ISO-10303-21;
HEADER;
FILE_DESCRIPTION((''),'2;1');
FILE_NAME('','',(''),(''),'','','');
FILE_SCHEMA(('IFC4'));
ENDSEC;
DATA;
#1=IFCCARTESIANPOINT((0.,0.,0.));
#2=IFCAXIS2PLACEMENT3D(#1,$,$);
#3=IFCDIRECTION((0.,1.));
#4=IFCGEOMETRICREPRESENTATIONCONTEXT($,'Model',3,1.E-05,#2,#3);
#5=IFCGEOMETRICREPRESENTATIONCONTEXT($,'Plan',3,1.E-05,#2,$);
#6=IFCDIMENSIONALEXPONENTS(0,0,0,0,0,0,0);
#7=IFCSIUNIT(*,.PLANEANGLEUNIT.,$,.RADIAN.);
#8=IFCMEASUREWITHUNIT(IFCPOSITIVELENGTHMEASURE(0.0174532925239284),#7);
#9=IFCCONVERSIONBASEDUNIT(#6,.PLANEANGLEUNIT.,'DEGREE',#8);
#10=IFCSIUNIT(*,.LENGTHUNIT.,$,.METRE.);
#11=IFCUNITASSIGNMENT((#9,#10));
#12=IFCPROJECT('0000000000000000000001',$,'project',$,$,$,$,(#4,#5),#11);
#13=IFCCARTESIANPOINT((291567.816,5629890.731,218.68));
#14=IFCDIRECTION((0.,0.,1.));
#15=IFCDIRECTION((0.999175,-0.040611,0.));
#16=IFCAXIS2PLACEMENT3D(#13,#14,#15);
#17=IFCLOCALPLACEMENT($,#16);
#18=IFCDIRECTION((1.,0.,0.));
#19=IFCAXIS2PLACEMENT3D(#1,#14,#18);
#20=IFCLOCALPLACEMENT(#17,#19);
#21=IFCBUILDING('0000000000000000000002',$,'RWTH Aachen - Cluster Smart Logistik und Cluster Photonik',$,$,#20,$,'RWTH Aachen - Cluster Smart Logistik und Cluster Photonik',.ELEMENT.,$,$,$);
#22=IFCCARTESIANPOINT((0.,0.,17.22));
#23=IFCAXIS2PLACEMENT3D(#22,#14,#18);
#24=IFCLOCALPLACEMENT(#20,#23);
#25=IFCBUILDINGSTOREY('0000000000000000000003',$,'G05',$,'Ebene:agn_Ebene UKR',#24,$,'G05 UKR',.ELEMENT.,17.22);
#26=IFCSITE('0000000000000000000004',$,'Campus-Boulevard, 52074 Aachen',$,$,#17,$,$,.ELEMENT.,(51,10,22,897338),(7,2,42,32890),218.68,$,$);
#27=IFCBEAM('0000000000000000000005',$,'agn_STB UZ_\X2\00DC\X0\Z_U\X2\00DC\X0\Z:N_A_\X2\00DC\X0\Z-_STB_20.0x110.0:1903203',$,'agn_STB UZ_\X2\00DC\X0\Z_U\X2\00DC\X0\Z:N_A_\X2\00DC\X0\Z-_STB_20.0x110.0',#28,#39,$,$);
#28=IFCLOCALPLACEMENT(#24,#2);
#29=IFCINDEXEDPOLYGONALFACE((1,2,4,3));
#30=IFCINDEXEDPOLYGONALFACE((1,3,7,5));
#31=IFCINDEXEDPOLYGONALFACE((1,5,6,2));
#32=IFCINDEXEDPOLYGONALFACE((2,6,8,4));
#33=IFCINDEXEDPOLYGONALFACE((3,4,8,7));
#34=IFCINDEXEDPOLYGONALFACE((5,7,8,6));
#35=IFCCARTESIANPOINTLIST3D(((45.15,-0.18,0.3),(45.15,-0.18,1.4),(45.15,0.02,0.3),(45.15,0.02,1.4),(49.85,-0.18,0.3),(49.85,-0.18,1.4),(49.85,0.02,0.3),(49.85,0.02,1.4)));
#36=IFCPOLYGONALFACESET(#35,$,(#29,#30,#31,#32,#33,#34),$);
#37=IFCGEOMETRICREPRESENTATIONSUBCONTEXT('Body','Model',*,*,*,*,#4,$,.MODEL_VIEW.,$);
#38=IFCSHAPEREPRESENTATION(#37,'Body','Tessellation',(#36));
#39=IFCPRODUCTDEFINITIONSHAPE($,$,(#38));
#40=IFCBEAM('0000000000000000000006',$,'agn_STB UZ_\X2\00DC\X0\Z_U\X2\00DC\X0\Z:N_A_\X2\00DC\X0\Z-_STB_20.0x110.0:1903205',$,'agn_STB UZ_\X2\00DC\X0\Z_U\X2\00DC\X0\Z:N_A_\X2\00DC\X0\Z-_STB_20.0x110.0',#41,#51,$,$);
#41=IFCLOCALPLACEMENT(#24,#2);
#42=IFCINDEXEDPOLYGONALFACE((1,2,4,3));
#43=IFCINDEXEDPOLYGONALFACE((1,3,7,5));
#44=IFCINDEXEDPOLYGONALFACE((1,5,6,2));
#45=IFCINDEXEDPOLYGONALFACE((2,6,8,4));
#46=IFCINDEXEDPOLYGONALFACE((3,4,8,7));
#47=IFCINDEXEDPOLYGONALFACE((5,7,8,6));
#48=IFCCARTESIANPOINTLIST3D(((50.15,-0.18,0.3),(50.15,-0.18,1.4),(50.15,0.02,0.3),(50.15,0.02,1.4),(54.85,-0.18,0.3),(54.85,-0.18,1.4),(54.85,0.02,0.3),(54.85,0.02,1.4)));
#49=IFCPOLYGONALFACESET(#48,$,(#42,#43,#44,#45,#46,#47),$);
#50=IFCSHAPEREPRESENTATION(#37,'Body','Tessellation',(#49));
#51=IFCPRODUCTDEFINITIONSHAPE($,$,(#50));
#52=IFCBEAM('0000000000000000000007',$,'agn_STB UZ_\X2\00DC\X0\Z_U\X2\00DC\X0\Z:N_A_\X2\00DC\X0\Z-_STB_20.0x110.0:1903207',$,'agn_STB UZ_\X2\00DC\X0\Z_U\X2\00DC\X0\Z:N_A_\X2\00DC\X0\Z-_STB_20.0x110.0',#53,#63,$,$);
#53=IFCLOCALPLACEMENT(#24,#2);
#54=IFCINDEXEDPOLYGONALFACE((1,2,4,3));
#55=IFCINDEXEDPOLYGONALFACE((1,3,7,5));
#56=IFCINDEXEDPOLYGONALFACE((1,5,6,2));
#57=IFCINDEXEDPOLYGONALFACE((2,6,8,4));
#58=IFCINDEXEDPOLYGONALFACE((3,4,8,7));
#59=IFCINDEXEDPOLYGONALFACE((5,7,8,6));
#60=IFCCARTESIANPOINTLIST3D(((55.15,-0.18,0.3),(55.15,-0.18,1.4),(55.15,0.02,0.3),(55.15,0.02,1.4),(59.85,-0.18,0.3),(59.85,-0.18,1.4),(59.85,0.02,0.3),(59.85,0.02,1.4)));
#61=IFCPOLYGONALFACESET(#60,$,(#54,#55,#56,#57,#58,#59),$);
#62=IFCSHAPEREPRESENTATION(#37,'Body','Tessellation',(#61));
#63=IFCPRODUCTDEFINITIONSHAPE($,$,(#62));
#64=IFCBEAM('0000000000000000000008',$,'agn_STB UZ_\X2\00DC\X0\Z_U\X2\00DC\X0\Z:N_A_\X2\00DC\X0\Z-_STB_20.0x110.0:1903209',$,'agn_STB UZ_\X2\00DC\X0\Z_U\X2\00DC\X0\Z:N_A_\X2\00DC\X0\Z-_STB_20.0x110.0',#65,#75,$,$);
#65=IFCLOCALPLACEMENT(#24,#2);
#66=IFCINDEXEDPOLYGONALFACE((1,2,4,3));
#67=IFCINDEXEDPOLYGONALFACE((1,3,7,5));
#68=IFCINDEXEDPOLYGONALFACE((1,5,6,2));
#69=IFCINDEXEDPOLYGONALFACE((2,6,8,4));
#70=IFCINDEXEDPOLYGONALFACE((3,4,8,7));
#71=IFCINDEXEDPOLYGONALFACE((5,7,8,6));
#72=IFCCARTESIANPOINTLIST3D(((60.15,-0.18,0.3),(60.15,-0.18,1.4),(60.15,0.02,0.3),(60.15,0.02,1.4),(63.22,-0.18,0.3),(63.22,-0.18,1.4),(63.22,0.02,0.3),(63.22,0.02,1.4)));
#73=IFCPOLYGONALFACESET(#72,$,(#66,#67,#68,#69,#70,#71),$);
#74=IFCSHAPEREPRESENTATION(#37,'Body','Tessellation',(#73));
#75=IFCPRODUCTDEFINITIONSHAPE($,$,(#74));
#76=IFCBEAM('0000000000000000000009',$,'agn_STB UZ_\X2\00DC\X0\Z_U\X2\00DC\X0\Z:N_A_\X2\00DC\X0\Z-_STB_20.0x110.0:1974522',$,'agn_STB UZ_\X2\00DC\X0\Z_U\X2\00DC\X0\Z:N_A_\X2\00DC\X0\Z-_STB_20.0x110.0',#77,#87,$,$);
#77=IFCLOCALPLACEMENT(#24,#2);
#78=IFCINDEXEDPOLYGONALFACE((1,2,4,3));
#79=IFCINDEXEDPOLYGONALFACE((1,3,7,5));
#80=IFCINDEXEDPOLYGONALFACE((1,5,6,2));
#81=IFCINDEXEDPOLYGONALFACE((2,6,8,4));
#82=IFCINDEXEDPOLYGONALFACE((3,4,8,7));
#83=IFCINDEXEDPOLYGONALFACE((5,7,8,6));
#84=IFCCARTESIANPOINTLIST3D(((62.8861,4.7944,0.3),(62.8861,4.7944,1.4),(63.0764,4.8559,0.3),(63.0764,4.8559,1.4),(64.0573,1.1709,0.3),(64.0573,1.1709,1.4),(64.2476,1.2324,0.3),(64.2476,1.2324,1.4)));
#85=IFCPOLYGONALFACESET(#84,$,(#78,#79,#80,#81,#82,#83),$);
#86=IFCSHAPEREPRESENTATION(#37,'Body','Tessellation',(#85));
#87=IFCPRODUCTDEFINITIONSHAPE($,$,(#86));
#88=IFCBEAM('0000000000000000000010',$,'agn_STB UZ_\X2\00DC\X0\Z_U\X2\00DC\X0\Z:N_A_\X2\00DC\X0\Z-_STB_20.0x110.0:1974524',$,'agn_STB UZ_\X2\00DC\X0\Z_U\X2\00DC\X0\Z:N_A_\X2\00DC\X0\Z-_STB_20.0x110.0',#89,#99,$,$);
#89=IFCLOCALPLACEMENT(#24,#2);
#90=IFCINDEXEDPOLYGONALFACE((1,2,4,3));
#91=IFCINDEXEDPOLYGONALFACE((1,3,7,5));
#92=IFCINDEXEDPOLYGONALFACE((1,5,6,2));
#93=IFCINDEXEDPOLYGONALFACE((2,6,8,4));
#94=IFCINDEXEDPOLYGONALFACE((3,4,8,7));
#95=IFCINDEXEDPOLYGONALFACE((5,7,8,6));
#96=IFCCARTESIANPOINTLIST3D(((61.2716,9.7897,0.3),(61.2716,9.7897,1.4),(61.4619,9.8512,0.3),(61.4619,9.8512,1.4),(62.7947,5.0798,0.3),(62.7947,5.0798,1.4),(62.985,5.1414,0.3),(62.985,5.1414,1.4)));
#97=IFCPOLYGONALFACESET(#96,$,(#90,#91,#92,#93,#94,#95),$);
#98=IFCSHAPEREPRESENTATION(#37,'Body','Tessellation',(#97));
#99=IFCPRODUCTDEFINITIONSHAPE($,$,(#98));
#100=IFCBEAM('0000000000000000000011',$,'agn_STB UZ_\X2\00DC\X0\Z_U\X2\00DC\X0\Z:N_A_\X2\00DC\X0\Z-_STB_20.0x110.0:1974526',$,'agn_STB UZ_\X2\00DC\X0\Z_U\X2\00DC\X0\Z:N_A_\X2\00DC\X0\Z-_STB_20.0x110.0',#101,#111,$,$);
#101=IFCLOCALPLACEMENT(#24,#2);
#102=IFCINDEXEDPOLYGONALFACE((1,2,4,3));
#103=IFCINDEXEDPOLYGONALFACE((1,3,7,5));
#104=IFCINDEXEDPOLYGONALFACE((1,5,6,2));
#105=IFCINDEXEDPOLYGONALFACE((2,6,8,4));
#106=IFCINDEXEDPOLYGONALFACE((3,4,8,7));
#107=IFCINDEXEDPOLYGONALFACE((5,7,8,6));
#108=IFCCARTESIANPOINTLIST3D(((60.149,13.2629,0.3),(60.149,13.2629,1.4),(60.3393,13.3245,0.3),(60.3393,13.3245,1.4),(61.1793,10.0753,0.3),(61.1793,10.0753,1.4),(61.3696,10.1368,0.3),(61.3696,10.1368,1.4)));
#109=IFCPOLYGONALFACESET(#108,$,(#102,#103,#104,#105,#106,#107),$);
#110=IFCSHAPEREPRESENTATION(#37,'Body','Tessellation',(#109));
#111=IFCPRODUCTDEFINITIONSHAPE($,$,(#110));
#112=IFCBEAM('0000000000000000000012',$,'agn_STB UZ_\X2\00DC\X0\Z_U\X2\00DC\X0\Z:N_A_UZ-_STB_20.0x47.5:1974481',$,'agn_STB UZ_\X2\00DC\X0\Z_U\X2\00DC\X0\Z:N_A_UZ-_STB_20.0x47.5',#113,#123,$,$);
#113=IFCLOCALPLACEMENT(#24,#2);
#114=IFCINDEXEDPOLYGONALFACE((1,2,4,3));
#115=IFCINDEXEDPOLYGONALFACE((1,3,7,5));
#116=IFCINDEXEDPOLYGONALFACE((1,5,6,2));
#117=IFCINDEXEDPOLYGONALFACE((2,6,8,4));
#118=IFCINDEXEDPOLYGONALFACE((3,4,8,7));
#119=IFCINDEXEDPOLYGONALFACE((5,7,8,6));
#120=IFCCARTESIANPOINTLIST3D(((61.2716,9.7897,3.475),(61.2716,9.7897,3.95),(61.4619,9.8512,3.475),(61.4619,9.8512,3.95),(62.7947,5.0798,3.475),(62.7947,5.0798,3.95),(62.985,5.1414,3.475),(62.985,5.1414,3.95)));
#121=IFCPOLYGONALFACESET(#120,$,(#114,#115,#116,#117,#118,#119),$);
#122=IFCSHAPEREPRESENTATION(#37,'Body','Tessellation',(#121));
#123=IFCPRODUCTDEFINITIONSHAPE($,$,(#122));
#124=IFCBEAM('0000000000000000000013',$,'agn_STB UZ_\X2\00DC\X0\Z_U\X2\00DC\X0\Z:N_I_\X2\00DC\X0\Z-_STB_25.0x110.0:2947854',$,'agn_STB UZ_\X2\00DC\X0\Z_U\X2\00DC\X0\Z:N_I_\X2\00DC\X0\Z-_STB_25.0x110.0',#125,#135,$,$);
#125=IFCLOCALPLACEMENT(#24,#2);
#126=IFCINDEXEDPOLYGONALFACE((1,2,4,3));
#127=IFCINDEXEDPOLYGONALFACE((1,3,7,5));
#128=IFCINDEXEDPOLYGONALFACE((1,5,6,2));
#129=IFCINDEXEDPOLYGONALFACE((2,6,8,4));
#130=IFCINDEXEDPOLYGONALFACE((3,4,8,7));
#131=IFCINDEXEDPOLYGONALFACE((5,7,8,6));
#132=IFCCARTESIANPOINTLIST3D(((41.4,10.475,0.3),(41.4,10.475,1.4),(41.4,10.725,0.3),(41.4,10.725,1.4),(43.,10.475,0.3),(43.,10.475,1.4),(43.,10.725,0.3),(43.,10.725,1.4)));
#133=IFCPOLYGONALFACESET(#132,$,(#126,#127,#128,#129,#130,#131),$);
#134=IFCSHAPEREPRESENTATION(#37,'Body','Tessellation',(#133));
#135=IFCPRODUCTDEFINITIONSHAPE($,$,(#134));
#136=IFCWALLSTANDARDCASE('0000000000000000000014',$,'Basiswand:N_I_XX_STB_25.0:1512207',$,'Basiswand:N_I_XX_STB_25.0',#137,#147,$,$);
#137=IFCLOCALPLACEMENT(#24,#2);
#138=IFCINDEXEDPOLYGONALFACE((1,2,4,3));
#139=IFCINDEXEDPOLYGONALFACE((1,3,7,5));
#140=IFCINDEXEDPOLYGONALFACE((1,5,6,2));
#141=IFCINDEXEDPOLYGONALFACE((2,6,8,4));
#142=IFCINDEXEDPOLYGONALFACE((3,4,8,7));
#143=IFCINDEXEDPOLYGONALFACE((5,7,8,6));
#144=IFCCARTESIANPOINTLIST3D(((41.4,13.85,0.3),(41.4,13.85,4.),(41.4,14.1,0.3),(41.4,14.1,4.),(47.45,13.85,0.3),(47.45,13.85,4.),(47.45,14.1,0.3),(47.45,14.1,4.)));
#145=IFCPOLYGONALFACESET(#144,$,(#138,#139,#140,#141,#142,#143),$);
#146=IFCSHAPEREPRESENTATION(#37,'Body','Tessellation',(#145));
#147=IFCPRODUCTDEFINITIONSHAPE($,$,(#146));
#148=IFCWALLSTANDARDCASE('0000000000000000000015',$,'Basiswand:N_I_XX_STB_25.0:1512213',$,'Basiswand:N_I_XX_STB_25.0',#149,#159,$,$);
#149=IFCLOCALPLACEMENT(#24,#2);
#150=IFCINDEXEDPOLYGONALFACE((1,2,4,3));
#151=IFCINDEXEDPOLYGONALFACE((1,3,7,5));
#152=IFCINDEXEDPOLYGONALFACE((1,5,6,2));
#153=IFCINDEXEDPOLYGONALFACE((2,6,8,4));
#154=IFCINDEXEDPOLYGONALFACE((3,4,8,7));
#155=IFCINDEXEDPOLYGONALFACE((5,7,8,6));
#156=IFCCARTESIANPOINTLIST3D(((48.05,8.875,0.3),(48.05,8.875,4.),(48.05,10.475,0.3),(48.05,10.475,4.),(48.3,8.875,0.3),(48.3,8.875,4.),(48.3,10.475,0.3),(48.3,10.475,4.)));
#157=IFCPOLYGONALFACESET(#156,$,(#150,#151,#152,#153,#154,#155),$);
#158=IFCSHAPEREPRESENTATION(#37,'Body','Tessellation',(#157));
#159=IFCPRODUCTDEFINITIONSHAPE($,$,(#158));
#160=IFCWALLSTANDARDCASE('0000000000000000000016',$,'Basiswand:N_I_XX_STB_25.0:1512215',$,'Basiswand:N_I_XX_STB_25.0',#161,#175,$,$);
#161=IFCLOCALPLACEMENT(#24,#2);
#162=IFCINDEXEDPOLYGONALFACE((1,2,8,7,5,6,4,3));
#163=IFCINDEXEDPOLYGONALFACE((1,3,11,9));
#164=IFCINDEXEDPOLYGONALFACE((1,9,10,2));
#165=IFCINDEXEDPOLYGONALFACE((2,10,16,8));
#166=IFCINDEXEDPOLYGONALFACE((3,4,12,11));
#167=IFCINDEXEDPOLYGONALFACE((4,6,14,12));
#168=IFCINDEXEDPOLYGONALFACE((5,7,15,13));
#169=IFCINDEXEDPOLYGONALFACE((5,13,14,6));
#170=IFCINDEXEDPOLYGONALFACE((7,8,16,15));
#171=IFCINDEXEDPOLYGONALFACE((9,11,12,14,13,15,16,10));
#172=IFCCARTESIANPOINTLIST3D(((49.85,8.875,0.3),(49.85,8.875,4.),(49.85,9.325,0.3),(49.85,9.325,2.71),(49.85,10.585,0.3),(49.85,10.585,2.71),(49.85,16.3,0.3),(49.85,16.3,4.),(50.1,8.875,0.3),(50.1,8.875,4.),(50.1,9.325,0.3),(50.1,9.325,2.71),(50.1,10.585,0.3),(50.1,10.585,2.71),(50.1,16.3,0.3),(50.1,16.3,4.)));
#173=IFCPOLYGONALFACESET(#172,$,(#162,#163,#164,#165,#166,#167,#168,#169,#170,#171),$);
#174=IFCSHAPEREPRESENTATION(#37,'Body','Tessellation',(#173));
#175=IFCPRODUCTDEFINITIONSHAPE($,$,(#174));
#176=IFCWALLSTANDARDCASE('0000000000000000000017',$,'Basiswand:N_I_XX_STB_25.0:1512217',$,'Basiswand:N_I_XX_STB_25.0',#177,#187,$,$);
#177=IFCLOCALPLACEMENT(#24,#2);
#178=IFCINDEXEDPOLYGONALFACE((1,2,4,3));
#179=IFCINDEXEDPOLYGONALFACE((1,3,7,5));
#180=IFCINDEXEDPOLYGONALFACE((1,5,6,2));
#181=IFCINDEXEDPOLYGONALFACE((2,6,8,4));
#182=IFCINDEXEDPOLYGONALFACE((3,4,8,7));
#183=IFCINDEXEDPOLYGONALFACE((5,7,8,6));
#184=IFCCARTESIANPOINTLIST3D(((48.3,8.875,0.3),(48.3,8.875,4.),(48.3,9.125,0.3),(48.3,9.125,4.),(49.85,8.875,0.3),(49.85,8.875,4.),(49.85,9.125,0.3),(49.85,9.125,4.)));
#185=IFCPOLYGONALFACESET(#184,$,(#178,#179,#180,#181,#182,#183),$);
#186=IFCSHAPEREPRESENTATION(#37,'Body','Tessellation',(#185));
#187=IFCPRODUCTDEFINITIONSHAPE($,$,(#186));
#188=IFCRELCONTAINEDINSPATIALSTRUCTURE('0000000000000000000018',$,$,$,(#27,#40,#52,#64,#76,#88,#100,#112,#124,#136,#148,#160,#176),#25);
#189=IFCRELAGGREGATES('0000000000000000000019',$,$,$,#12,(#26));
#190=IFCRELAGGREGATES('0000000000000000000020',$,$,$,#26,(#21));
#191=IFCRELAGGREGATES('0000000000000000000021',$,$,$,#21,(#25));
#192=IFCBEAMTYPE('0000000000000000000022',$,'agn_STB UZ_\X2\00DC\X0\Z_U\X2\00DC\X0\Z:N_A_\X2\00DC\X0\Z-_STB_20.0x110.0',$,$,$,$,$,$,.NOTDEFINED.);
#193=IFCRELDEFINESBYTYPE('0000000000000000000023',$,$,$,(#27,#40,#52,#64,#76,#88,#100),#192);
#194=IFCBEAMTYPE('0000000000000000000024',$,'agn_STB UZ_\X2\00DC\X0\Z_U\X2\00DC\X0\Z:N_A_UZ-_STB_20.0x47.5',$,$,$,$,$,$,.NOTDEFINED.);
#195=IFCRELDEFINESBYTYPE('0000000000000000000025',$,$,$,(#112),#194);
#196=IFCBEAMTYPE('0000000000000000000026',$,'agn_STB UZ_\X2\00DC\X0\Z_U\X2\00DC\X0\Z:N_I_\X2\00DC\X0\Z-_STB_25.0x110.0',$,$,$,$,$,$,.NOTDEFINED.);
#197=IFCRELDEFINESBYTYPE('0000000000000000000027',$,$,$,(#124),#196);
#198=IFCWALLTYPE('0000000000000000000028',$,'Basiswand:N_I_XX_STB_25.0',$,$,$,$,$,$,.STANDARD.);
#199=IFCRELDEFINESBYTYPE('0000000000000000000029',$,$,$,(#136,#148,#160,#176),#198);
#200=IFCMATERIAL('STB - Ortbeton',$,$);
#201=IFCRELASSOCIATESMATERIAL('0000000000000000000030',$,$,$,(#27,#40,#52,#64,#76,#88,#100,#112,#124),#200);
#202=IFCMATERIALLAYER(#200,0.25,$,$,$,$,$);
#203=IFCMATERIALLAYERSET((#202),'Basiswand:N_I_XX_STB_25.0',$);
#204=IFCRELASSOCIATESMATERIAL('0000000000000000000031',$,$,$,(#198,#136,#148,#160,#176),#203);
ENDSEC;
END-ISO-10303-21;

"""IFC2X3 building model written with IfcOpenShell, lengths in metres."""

from ifc_helpers import new_model, entity, si_unit, converted_unit, direction, frame, frame_2d, origin, origin_with_axes, place, context, subcontext, project, spatial, rectangle, extrude, material, layer, layer_set, layer_usage, type_object, element, save


model = new_model("IFC2X3")

# Units and contexts
model_context = context("Model", 3, precision=1e-05, world=origin(), true_north=direction((0.0, 1.0)))
plan_context = context("Plan", 3, precision=1e-05, world=origin())
body_context = subcontext(model_context, "Body", "Model", "MODEL_VIEW")
ifc_project = project(units=[converted_unit("PLANEANGLEUNIT", "DEGREE", entity("IfcPositiveLengthMeasure", 0.0174532925239284), si_unit("PLANEANGLEUNIT", "RADIAN"), dimensions=[0, 0, 0, 0, 0, 0, 0]), si_unit("LENGTHUNIT", "METRE")], contexts=[model_context, plan_context])

# Site, building, storey
site_placement = place(None, frame((291567.816, 5629890.731, 218.68), z_axis=(0.0, 0.0, 1.0), x_axis=(0.999175, -0.040611, 0.0)))
site = spatial("IfcSite", under=ifc_project, at=site_placement, Name="Campus-Boulevard, 52074 Aachen", CompositionType="ELEMENT", RefLatitude=(51, 10, 22, 897338), RefLongitude=(7, 2, 42, 32890), RefElevation=218.68)
building_placement = place(site_placement, origin_with_axes())
building = spatial("IfcBuilding", under=site, at=building_placement, Name="RWTH Aachen - Cluster Smart Logistik und Cluster Photonik", LongName="RWTH Aachen - Cluster Smart Logistik und Cluster Photonik", CompositionType="ELEMENT")
storey_placement = place(building_placement, frame((0.0, 0.0, 17.22), z_axis=(0.0, 0.0, 1.0), x_axis=(1.0, 0.0, 0.0)))
storey = spatial("IfcBuildingStorey", under=building, at=storey_placement, Name="G05", ObjectType="Ebene:agn_Ebene UKR", LongName="G05 UKR", CompositionType="ELEMENT", Elevation=17.22)

# Beams
ifc_material_1 = material(Name="STB - Ortbeton")
beam_type_1 = type_object("IfcBeamType", Name="agn_STB UZ_ÜZ_UÜZ:N_A_ÜZ-_STB_20.0x110.0", PredefinedType="NOTDEFINED")
for number, where, z_axis, x_axis, name in (
    (1, (45.15, -0.08, 0.3), (0.0, 0.0, 1.0), (1.0, 0.0, 0.0), "agn_STB UZ_ÜZ_UÜZ:N_A_ÜZ-_STB_20.0x110.0:1903203"),
    (2, (50.15, -0.08, 0.3), (0.0, 0.0, 1.0), (1.0, 0.0, 0.0), "agn_STB UZ_ÜZ_UÜZ:N_A_ÜZ-_STB_20.0x110.0:1903205"),
    (3, (55.15, -0.08, 0.3), (0.0, 0.0, 1.0), (1.0, 0.0, 0.0), "agn_STB UZ_ÜZ_UÜZ:N_A_ÜZ-_STB_20.0x110.0:1903207"),
):
    element("IfcBeam", number, at=place(storey_placement, frame(where, z_axis=z_axis, x_axis=x_axis)), inside=storey, type_object=beam_type_1, material=ifc_material_1, Name=name, ObjectType="agn_STB UZ_ÜZ_UÜZ:N_A_ÜZ-_STB_20.0x110.0", context=body_context, shape_type="SweptSolid", body=[
        extrude(rectangle(XDim=1.1, YDim=0.2, at=frame_2d((0.0, 0.0), x_axis=(1.0, 0.0))), frame((0.0, 0.0, 0.55), z_axis=(1.0, 0.0, 0.0), x_axis=(0.0, 0.0, -1.0)), (0.0, 0.0, 1.0), 4.7),
    ])
beam_1_placement = place(storey_placement, frame((60.15, -0.08, 0.3), z_axis=(0.0, 0.0, 1.0), x_axis=(1.0, 0.0, 0.0)))
element("IfcBeam", 4, at=beam_1_placement, inside=storey, type_object=beam_type_1, material=ifc_material_1, Name="agn_STB UZ_ÜZ_UÜZ:N_A_ÜZ-_STB_20.0x110.0:1903209", ObjectType="agn_STB UZ_ÜZ_UÜZ:N_A_ÜZ-_STB_20.0x110.0", context=body_context, shape_type="SweptSolid", body=[
    extrude(rectangle(XDim=1.1, YDim=0.2, at=frame_2d((0.0, 0.0), x_axis=(1.0, 0.0))), frame((0.0, 0.0, 0.55), z_axis=(1.0, 0.0, 0.0), x_axis=(0.0, 0.0, -1.0)), (0.0, 0.0, 1.0), 3.07),
])
beam_2_placement = place(storey_placement, frame((62.9812, 4.8253, 0.3), z_axis=(0.0, 0.0, 1.0), x_axis=(0.307544, -0.951534, 0.0)))
element("IfcBeam", 5, at=beam_2_placement, inside=storey, type_object=beam_type_1, material=ifc_material_1, Name="agn_STB UZ_ÜZ_UÜZ:N_A_ÜZ-_STB_20.0x110.0:1974522", ObjectType="agn_STB UZ_ÜZ_UÜZ:N_A_ÜZ-_STB_20.0x110.0", context=body_context, shape_type="SweptSolid", body=[
    extrude(rectangle(XDim=1.1, YDim=0.2, at=frame_2d((0.0, 0.0), x_axis=(1.0, 0.0))), frame((0.0001, 0.0, 0.55), z_axis=(1.0, 0.0, 0.0), x_axis=(0.0, 0.0, -1.0)), (0.0, 0.0, 1.0), 3.8081),
])
beam_3_placement = place(storey_placement, frame((61.3667, 9.8206, 0.3), z_axis=(0.0, 0.0, 1.0), x_axis=(0.307689, -0.951487, 0.0)))
element("IfcBeam", 6, at=beam_3_placement, inside=storey, type_object=beam_type_1, material=ifc_material_1, Name="agn_STB UZ_ÜZ_UÜZ:N_A_ÜZ-_STB_20.0x110.0:1974524", ObjectType="agn_STB UZ_ÜZ_UÜZ:N_A_ÜZ-_STB_20.0x110.0", context=body_context, shape_type="SweptSolid", body=[
    extrude(rectangle(XDim=1.1, YDim=0.2, at=frame_2d((0.0, 0.0), x_axis=(1.0, 0.0))), frame((0.0002, 0.0, 0.55), z_axis=(1.0, 0.0, 0.0), x_axis=(0.0, 0.0, -1.0)), (0.0, 0.0, 1.0), 4.95),
])
beam_4_placement = place(storey_placement, frame((60.2441, 13.294, 0.3), z_axis=(0.0, 0.0, 1.0), x_axis=(0.307544, -0.951534, 0.0)))
element("IfcBeam", 7, at=beam_4_placement, inside=storey, type_object=beam_type_1, material=ifc_material_1, Name="agn_STB UZ_ÜZ_UÜZ:N_A_ÜZ-_STB_20.0x110.0:1974526", ObjectType="agn_STB UZ_ÜZ_UÜZ:N_A_ÜZ-_STB_20.0x110.0", context=body_context, shape_type="SweptSolid", body=[
    extrude(rectangle(XDim=1.1, YDim=0.2, at=frame_2d((0.0, 0.0), x_axis=(1.0, 0.0))), frame((0.0003, 0.0, 0.55), z_axis=(1.0, 0.0, 0.0), x_axis=(0.0, 0.0, -1.0)), (0.0, 0.0, 1.0), 3.35),
])
beam_type_2 = type_object("IfcBeamType", Name="agn_STB UZ_ÜZ_UÜZ:N_A_UZ-_STB_20.0x47.5", PredefinedType="NOTDEFINED")
beam_5_placement = place(storey_placement, frame((61.3667, 9.8206, 0.3), z_axis=(0.0, 0.0, 1.0), x_axis=(0.307689, -0.951487, 0.0)))
element("IfcBeam", 8, at=beam_5_placement, inside=storey, type_object=beam_type_2, material=ifc_material_1, Name="agn_STB UZ_ÜZ_UÜZ:N_A_UZ-_STB_20.0x47.5:1974481", ObjectType="agn_STB UZ_ÜZ_UÜZ:N_A_UZ-_STB_20.0x47.5", context=body_context, shape_type="SweptSolid", body=[
    extrude(rectangle(XDim=0.475, YDim=0.2, at=frame_2d((0.0, 0.0), x_axis=(1.0, 0.0))), frame((0.0002, 0.0, 3.4125), z_axis=(1.0, 0.0, 0.0), x_axis=(0.0, 0.0, -1.0)), (0.0, 0.0, 1.0), 4.95),
])
beam_type_3 = type_object("IfcBeamType", Name="agn_STB UZ_ÜZ_UÜZ:N_I_ÜZ-_STB_25.0x110.0", PredefinedType="NOTDEFINED")
beam_6_placement = place(storey_placement, frame((43.1, 10.6, 0.3), z_axis=(0.0, 0.0, 1.0), x_axis=(-1.0, 0.0, 0.0)))
element("IfcBeam", 9, at=beam_6_placement, inside=storey, type_object=beam_type_3, material=ifc_material_1, Name="agn_STB UZ_ÜZ_UÜZ:N_I_ÜZ-_STB_25.0x110.0:2947854", ObjectType="agn_STB UZ_ÜZ_UÜZ:N_I_ÜZ-_STB_25.0x110.0", context=body_context, shape_type="SweptSolid", body=[
    extrude(rectangle(XDim=1.1, YDim=0.25, at=frame_2d((0.0, 0.0), x_axis=(1.0, 0.0))), frame((0.1, 0.0, 0.55), z_axis=(1.0, 0.0, 0.0), x_axis=(0.0, 0.0, -1.0)), (0.0, 0.0, 1.0), 1.6),
])

# Walls
ifc_layer_1 = layer(ifc_material_1, 0.25)
ifc_layer_set_1 = layer_set([ifc_layer_1], Name="Basiswand:N_I_XX_STB_25.0")
ifc_layer_usage_1 = layer_usage(ifc_layer_set_1, "AXIS2", "NEGATIVE", 0.125)
wall_type_1 = type_object("IfcWallType", Name="Basiswand:N_I_XX_STB_25.0", PredefinedType="STANDARD", material=ifc_layer_set_1)
wall_1_placement = place(storey_placement, frame((41.4, 13.975, 0.3), z_axis=(0.0, 0.0, 1.0), x_axis=(1.0, 0.0, 0.0)))
element("IfcWallStandardCase", 10, at=wall_1_placement, inside=storey, type_object=wall_type_1, material=ifc_layer_usage_1, Name="Basiswand:N_I_XX_STB_25.0:1512207", ObjectType="Basiswand:N_I_XX_STB_25.0", context=body_context, shape_type="SweptSolid", body=[
    extrude(rectangle(XDim=6.05, YDim=0.25, at=frame_2d((3.025, 0.0), x_axis=(-1.0, 0.0))), origin(), (0.0, 0.0, 1.0), 3.7),
])
ifc_layer_usage_2 = layer_usage(ifc_layer_set_1, "AXIS2", "NEGATIVE", 0.125)
wall_2_placement = place(storey_placement, frame((48.175, 8.875, 0.3), z_axis=(0.0, 0.0, 1.0), x_axis=(0.0, 1.0, 0.0)))
element("IfcWallStandardCase", 11, at=wall_2_placement, inside=storey, type_object=wall_type_1, material=ifc_layer_usage_2, Name="Basiswand:N_I_XX_STB_25.0:1512213", ObjectType="Basiswand:N_I_XX_STB_25.0", context=body_context, shape_type="SweptSolid", body=[
    extrude(rectangle(XDim=1.6, YDim=0.25, at=frame_2d((0.8, 0.0), x_axis=(-1.0, 0.0))), origin(), (0.0, 0.0, 1.0), 3.7),
])

# Wall, opening
ifc_layer_usage_3 = layer_usage(ifc_layer_set_1, "AXIS2", "NEGATIVE", 0.125)
wall_3_placement = place(storey_placement, frame((49.975, 8.875, 0.3), z_axis=(0.0, 0.0, 1.0), x_axis=(0.0, 1.0, 0.0)))
wall_3 = element("IfcWallStandardCase", 12, at=wall_3_placement, inside=storey, type_object=wall_type_1, material=ifc_layer_usage_3, Name="Basiswand:N_I_XX_STB_25.0:1512215", ObjectType="Basiswand:N_I_XX_STB_25.0", context=body_context, shape_type="SweptSolid", body=[
    extrude(rectangle(XDim=7.425, YDim=0.25, at=frame_2d((3.7125, 0.0), x_axis=(-1.0, 0.0))), origin(), (0.0, 0.0, 1.0), 3.7),
])
opening_1_placement = place(wall_3_placement, frame((0.45, -0.125, 0.0), z_axis=(0.0, 0.0, 1.0), x_axis=(1.0, 0.0, 0.0)))
element("IfcOpeningElement", 13, at=opening_1_placement, cuts=wall_3, ObjectType="Opening", context=body_context, shape_type="SweptSolid", body=[
    extrude(rectangle(XDim=2.41, YDim=1.26, at=frame_2d((1.205, 0.63), x_axis=(1.0, 0.0))), frame((0.0, 0.0, 0.0), z_axis=(0.0, 1.0, 0.0), x_axis=(0.0, 0.0, 1.0)), (0.0, 0.0, 1.0), 0.25),
])

# Wall
ifc_layer_usage_4 = layer_usage(ifc_layer_set_1, "AXIS2", "NEGATIVE", 0.125)
wall_4_placement = place(storey_placement, frame((48.3, 9.0, 0.3), z_axis=(0.0, 0.0, 1.0), x_axis=(1.0, 0.0, 0.0)))
element("IfcWallStandardCase", 14, at=wall_4_placement, inside=storey, type_object=wall_type_1, material=ifc_layer_usage_4, Name="Basiswand:N_I_XX_STB_25.0:1512217", ObjectType="Basiswand:N_I_XX_STB_25.0", context=body_context, shape_type="SweptSolid", body=[
    extrude(rectangle(XDim=1.55, YDim=0.25, at=frame_2d((0.775, 0.0), x_axis=(-1.0, 0.0))), origin(), (0.0, 0.0, 1.0), 3.7),
])

save(model, "model.ifc")
